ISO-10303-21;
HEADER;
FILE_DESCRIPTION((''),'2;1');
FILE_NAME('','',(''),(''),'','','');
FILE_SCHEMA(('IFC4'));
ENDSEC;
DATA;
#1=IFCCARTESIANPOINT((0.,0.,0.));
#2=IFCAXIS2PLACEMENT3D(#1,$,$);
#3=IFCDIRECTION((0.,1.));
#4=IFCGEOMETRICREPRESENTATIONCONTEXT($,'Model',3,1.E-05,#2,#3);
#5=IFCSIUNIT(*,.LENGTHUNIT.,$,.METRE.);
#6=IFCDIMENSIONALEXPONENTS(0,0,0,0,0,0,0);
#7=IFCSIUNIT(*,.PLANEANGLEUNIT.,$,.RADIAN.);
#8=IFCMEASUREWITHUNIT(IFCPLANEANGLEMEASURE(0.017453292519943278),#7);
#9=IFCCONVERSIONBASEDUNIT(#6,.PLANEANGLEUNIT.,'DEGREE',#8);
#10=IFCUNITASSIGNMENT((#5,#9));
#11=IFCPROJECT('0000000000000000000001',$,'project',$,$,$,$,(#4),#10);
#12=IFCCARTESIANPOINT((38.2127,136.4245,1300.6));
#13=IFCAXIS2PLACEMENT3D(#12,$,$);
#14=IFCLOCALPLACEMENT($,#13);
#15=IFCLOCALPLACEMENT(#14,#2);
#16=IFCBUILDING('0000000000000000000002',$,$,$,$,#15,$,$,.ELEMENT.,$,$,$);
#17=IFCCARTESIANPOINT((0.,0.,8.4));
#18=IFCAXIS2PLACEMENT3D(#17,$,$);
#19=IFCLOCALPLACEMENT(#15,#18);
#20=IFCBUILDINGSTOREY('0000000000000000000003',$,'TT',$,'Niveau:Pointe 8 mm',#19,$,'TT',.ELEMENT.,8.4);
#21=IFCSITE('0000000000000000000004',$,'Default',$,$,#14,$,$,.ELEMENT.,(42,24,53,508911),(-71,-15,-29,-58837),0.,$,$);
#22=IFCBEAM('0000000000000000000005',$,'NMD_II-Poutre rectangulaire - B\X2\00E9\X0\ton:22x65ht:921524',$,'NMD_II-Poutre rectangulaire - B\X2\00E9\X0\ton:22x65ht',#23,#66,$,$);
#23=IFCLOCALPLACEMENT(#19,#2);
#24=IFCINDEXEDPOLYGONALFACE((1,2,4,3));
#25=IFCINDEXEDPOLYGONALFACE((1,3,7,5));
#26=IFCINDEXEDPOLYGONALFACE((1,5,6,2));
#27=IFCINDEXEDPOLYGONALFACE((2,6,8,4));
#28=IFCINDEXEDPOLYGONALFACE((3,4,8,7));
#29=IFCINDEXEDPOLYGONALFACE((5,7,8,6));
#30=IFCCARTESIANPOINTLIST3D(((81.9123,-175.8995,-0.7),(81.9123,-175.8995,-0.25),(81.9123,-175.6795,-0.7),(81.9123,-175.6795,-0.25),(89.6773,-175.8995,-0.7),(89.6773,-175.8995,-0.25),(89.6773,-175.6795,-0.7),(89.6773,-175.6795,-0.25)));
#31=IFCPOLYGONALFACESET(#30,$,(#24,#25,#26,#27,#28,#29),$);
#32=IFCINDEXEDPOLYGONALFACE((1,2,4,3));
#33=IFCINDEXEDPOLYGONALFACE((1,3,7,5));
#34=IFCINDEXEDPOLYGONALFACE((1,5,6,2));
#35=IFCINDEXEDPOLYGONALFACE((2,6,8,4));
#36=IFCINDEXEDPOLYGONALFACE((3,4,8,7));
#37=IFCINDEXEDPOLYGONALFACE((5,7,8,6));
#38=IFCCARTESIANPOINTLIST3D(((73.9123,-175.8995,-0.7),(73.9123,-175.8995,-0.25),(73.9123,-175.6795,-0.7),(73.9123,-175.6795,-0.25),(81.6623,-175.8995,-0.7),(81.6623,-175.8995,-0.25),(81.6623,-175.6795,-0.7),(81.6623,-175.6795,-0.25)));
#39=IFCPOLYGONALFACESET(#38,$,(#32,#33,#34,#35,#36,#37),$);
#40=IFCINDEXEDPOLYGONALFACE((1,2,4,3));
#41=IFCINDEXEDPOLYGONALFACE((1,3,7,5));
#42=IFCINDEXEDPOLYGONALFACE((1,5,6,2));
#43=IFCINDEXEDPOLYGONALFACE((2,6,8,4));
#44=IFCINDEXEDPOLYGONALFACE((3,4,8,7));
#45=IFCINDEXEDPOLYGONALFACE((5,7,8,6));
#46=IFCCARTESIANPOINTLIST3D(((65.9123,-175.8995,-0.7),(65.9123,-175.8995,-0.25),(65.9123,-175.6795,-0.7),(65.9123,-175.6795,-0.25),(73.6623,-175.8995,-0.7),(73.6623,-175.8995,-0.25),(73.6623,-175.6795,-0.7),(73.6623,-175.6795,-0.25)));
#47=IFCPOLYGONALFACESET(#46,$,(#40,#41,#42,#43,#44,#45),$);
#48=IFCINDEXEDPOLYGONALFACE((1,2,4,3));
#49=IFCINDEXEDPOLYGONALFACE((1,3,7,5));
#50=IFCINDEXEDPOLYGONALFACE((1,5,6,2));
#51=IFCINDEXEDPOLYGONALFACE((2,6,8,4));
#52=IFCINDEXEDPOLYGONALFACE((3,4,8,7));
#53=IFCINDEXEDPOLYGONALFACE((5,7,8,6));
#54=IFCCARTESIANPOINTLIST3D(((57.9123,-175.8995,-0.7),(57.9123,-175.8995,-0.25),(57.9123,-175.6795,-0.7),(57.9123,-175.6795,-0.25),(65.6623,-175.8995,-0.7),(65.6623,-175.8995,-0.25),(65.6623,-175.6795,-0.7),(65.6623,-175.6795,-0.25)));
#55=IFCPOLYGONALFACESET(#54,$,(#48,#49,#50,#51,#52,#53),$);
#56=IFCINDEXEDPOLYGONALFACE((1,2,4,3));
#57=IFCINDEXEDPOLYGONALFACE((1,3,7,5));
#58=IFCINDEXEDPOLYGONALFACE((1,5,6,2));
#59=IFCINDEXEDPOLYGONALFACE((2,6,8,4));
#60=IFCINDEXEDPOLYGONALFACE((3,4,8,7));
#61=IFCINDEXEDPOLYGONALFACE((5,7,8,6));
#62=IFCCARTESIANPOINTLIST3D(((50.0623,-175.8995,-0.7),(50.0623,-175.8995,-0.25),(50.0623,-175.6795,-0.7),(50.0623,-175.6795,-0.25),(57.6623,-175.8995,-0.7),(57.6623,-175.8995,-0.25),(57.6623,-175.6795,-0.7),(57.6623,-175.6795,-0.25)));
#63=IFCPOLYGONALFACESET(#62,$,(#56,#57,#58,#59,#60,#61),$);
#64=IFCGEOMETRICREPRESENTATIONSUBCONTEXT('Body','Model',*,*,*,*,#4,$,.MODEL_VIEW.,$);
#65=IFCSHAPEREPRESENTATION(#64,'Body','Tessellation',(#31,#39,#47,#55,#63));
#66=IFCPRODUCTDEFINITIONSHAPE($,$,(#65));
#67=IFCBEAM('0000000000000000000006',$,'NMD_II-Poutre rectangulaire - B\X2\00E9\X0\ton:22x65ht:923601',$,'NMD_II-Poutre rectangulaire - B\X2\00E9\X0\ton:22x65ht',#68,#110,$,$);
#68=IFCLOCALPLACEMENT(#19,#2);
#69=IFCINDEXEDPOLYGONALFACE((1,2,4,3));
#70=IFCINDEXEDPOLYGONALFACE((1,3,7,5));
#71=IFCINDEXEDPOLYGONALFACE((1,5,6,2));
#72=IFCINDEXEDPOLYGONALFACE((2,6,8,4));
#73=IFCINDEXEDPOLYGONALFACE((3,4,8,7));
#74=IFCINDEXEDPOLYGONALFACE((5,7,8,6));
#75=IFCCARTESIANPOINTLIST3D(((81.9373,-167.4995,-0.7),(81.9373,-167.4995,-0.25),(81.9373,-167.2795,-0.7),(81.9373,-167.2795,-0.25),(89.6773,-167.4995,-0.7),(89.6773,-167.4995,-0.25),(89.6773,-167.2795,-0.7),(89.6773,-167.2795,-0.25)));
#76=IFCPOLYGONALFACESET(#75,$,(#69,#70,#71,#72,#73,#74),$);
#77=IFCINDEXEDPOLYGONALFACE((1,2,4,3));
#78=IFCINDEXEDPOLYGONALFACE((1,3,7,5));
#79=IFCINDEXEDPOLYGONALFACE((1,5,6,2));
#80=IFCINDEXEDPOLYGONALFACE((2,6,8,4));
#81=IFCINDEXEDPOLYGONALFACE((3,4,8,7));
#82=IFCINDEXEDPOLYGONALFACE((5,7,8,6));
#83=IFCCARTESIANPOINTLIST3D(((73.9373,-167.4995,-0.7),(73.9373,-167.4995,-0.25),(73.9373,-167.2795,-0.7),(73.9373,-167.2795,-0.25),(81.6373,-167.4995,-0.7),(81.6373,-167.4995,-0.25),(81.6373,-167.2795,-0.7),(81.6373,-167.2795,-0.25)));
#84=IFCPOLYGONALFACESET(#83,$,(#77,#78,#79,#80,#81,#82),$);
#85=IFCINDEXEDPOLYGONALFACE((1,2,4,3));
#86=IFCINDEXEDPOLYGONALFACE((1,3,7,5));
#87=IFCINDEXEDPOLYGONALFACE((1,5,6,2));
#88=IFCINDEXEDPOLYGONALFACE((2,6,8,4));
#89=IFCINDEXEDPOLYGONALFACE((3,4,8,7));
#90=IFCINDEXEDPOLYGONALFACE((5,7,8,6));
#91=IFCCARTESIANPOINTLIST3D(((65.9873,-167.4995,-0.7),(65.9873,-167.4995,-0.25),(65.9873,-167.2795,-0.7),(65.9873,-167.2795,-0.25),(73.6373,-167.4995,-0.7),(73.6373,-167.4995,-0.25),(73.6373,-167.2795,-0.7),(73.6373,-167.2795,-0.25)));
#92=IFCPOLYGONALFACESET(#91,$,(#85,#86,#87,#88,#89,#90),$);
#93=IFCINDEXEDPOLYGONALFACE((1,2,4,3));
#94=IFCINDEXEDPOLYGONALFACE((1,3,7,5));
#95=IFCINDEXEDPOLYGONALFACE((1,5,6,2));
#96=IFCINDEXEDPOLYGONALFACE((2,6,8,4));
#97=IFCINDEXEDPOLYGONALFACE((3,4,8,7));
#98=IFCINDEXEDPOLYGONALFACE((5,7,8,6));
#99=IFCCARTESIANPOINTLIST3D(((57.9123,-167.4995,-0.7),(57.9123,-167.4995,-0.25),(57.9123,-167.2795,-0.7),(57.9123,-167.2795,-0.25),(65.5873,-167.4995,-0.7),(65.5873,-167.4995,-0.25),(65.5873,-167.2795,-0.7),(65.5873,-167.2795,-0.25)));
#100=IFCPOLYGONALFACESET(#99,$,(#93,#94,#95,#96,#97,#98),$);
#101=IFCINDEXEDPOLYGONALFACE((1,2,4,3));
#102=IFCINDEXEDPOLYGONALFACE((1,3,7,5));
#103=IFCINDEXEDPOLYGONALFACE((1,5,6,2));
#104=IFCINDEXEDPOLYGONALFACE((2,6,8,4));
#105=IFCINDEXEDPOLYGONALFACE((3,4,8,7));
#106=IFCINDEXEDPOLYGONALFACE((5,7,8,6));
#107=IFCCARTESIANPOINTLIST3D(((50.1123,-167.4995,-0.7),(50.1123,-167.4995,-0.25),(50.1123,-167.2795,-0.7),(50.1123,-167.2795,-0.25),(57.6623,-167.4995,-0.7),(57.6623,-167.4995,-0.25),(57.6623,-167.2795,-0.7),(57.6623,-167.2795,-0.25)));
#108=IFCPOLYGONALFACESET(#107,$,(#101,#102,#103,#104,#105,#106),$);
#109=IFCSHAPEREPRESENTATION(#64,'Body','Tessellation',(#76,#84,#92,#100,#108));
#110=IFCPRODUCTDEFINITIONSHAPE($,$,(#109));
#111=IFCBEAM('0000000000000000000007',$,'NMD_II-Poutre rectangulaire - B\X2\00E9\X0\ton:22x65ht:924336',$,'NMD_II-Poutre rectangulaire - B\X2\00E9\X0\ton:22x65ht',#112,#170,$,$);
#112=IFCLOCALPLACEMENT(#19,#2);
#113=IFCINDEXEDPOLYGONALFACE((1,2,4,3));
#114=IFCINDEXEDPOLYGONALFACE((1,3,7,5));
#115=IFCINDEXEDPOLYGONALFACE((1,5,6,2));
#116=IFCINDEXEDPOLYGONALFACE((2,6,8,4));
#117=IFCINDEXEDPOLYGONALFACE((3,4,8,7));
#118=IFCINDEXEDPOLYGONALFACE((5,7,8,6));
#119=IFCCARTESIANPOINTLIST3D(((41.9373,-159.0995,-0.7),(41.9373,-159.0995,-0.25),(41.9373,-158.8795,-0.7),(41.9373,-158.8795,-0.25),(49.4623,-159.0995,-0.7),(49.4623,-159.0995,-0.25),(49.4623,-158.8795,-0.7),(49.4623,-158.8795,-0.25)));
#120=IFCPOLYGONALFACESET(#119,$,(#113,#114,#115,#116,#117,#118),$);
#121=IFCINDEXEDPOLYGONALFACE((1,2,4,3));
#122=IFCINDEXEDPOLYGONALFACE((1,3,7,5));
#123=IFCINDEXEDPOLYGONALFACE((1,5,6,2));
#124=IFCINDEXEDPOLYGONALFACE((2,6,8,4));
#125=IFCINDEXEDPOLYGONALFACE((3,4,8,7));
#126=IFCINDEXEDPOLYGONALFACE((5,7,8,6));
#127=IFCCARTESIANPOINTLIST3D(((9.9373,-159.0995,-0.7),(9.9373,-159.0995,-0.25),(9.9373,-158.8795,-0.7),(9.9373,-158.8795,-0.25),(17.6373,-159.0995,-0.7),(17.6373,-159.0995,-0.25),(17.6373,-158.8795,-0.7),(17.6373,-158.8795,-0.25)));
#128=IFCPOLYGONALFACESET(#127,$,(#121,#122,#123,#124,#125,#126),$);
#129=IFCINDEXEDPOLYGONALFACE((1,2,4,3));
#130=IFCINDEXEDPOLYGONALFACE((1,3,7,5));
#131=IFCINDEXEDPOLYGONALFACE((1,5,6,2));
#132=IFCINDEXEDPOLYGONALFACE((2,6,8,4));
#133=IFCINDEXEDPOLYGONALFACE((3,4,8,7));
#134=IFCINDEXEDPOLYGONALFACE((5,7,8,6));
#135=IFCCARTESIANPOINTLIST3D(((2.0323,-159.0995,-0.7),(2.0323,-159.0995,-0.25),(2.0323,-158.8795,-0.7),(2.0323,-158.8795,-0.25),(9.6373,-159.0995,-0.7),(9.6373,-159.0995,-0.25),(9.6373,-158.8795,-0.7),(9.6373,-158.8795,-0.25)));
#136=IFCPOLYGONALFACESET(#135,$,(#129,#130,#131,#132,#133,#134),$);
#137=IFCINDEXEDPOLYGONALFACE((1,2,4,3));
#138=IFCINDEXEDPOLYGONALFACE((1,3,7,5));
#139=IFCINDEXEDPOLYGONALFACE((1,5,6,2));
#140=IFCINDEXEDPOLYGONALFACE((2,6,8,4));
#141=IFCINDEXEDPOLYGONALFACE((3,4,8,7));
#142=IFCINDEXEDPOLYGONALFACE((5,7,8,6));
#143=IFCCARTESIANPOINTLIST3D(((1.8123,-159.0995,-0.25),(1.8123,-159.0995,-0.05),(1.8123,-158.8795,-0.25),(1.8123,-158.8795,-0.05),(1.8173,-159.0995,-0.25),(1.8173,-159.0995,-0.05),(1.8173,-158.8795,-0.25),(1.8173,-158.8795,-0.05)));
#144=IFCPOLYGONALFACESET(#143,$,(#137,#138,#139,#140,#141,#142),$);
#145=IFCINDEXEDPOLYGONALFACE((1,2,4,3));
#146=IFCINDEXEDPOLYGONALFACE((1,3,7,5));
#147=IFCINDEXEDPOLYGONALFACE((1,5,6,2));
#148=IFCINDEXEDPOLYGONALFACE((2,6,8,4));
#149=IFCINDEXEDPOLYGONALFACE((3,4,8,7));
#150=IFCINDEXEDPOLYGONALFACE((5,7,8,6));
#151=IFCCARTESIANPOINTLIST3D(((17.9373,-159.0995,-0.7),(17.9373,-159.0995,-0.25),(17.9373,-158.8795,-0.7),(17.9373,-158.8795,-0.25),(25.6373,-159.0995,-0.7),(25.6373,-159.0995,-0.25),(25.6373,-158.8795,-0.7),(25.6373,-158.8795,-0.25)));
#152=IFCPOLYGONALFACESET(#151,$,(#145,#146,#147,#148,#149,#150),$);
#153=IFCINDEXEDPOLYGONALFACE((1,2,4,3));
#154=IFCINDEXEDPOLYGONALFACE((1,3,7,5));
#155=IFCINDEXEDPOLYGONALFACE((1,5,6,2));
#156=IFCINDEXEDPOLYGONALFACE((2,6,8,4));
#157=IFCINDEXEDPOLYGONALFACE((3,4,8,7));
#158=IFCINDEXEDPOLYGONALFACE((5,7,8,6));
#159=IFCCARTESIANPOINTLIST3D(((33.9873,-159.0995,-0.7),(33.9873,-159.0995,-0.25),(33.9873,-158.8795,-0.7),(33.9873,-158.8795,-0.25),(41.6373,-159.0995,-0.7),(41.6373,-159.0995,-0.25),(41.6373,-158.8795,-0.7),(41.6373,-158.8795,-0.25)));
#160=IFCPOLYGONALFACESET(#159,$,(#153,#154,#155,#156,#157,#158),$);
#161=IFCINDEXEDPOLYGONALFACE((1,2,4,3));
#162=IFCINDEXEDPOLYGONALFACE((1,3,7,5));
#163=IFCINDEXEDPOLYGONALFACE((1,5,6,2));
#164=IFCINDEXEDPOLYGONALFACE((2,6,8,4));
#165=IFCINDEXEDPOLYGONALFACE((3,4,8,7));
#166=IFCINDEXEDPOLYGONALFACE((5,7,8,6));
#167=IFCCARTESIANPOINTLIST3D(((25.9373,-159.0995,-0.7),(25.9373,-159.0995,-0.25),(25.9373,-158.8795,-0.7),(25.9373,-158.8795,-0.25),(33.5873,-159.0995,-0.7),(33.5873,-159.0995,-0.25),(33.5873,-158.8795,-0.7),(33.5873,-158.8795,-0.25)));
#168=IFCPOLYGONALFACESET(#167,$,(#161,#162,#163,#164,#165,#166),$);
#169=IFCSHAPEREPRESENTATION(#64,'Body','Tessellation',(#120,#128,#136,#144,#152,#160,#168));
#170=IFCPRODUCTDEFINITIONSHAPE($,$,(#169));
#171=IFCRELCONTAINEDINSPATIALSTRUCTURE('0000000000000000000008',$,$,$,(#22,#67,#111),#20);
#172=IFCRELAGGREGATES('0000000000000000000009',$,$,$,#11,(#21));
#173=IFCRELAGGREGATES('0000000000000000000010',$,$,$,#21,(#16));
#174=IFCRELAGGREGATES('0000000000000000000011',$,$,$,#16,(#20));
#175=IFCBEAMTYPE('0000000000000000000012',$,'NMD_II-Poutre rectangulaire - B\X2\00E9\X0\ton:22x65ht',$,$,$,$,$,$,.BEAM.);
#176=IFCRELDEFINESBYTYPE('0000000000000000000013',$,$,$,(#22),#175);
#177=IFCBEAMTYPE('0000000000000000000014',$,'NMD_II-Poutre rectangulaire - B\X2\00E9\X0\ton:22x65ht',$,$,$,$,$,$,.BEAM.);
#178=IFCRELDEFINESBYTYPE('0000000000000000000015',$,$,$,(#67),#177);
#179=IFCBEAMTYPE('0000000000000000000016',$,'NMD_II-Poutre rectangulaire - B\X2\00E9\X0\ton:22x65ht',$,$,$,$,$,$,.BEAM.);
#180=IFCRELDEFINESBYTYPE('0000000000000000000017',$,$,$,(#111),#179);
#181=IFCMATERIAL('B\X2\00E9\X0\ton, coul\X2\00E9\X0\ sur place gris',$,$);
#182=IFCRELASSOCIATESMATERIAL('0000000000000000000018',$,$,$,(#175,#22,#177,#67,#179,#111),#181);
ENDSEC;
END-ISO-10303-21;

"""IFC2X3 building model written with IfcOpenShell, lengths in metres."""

from ifc_helpers import new_model, entity, si_unit, converted_unit, direction, frame, frame_2d, origin, place, context, subcontext, project, spatial, rectangle, extrude, source, transform, mapped, material, type_object, type_shapes, element, save


model = new_model("IFC2X3")

# Units and contexts
model_context = context("Model", 3, precision=1e-05, world=origin(), true_north=direction((0.0, 1.0)))
body_context = subcontext(model_context, "Body", "Model", "MODEL_VIEW")
ifc_project = project(units=[si_unit("LENGTHUNIT", "METRE"), converted_unit("PLANEANGLEUNIT", "DEGREE", entity("IfcPlaneAngleMeasure", 0.017453292519943278), si_unit("PLANEANGLEUNIT", "RADIAN"), dimensions=[0, 0, 0, 0, 0, 0, 0])], contexts=[model_context])

# Site, building, storey
site_placement = place(None, frame((38.2127, 136.4245, 1300.6)))
site = spatial("IfcSite", under=ifc_project, at=site_placement, Name="Default", CompositionType="ELEMENT", RefLatitude=(42, 24, 53, 508911), RefLongitude=(-71, -15, -29, -58837), RefElevation=0.0)
building_placement = place(site_placement, origin())
building = spatial("IfcBuilding", under=site, at=building_placement, CompositionType="ELEMENT")
storey_placement = place(building_placement, frame((0.0, 0.0, 8.4)))
storey = spatial("IfcBuildingStorey", under=building, at=storey_placement, Name="TT", ObjectType="Niveau:Pointe 8 mm", LongName="TT", CompositionType="ELEMENT", Elevation=8.4)

# Beams
ifc_material_1 = material(Name="Béton, coulé sur place gris")
beam_type_1 = type_object("IfcBeamType", Name="NMD_II-Poutre rectangulaire - Béton:22x65ht", PredefinedType="BEAM", material=ifc_material_1)
shared_shape_1 = source(origin(), body_context, "Body", "SweptSolid", [
    extrude(rectangle(XDim=0.45, YDim=0.22, at=frame_2d((0.0, 0.0), x_axis=(1.0, 0.0))), frame((81.9123, -175.7895, 7.925), z_axis=(1.0, 0.0, 0.0), x_axis=(0.0, 0.0, -1.0)), (0.0, 0.0, 1.0), 7.765),
    extrude(rectangle(XDim=0.45, YDim=0.22, at=frame_2d((0.0, 0.0), x_axis=(1.0, 0.0))), frame((73.9123, -175.7895, 7.925), z_axis=(1.0, 0.0, 0.0), x_axis=(0.0, 0.0, -1.0)), (0.0, 0.0, 1.0), 7.75),
    extrude(rectangle(XDim=0.45, YDim=0.22, at=frame_2d((0.0, 0.0), x_axis=(1.0, 0.0))), frame((65.9123, -175.7895, 7.925), z_axis=(1.0, 0.0, 0.0), x_axis=(0.0, 0.0, -1.0)), (0.0, 0.0, 1.0), 7.75),
    extrude(rectangle(XDim=0.45, YDim=0.22, at=frame_2d((0.0, 0.0), x_axis=(1.0, 0.0))), frame((57.9123, -175.7895, 7.925), z_axis=(1.0, 0.0, 0.0), x_axis=(0.0, 0.0, -1.0)), (0.0, 0.0, 1.0), 7.75),
    extrude(rectangle(XDim=0.45, YDim=0.22, at=frame_2d((0.0, 0.0), x_axis=(1.0, 0.0))), frame((50.0623, -175.7895, 7.925), z_axis=(1.0, 0.0, 0.0), x_axis=(0.0, 0.0, -1.0)), (0.0, 0.0, 1.0), 7.6),
])
type_shapes(beam_type_1, [shared_shape_1])
beam_1_placement = place(storey_placement, frame((0.0, 0.0, -8.4)))
element("IfcBeam", 1, at=beam_1_placement, inside=storey, type_object=beam_type_1, material=ifc_material_1, Name="NMD_II-Poutre rectangulaire - Béton:22x65ht:921524", ObjectType="NMD_II-Poutre rectangulaire - Béton:22x65ht", context=body_context, shape_type="MappedRepresentation", body=[
    mapped(shared_shape_1, transform((0.0, 0.0, 0.0), scale=1.0)),
])
beam_type_2 = type_object("IfcBeamType", Name="NMD_II-Poutre rectangulaire - Béton:22x65ht", PredefinedType="BEAM", material=ifc_material_1)
shared_shape_2 = source(origin(), body_context, "Body", "SweptSolid", [
    extrude(rectangle(XDim=0.45, YDim=0.22, at=frame_2d((0.0, 0.0), x_axis=(1.0, 0.0))), frame((81.9373, -167.3895, 7.925), z_axis=(1.0, 0.0, 0.0), x_axis=(0.0, 0.0, -1.0)), (0.0, 0.0, 1.0), 7.74),
    extrude(rectangle(XDim=0.45, YDim=0.22, at=frame_2d((0.0, 0.0), x_axis=(1.0, 0.0))), frame((73.9373, -167.3895, 7.925), z_axis=(1.0, 0.0, 0.0), x_axis=(0.0, 0.0, -1.0)), (0.0, 0.0, 1.0), 7.7),
    extrude(rectangle(XDim=0.45, YDim=0.22, at=frame_2d((0.0, 0.0), x_axis=(1.0, 0.0))), frame((65.9873, -167.3895, 7.925), z_axis=(1.0, 0.0, 0.0), x_axis=(0.0, 0.0, -1.0)), (0.0, 0.0, 1.0), 7.65),
    extrude(rectangle(XDim=0.45, YDim=0.22, at=frame_2d((0.0, 0.0), x_axis=(1.0, 0.0))), frame((57.9123, -167.3895, 7.925), z_axis=(1.0, 0.0, 0.0), x_axis=(0.0, 0.0, -1.0)), (0.0, 0.0, 1.0), 7.675),
    extrude(rectangle(XDim=0.45, YDim=0.22, at=frame_2d((0.0, 0.0), x_axis=(1.0, 0.0))), frame((50.1123, -167.3895, 7.925), z_axis=(1.0, 0.0, 0.0), x_axis=(0.0, 0.0, -1.0)), (0.0, 0.0, 1.0), 7.55),
])
type_shapes(beam_type_2, [shared_shape_2])
beam_2_placement = place(storey_placement, frame((0.0, 0.0, -8.4)))
element("IfcBeam", 2, at=beam_2_placement, inside=storey, type_object=beam_type_2, material=ifc_material_1, Name="NMD_II-Poutre rectangulaire - Béton:22x65ht:923601", ObjectType="NMD_II-Poutre rectangulaire - Béton:22x65ht", context=body_context, shape_type="MappedRepresentation", body=[
    mapped(shared_shape_2, transform((0.0, 0.0, 0.0), scale=1.0)),
])
beam_type_3 = type_object("IfcBeamType", Name="NMD_II-Poutre rectangulaire - Béton:22x65ht", PredefinedType="BEAM", material=ifc_material_1)
shared_shape_3 = source(origin(), body_context, "Body", "SweptSolid", [
    extrude(rectangle(XDim=0.45, YDim=0.22, at=frame_2d((0.0, 0.0), x_axis=(1.0, 0.0))), frame((41.9373, -158.9895, 7.925), z_axis=(1.0, 0.0, 0.0), x_axis=(0.0, 0.0, -1.0)), (0.0, 0.0, 1.0), 7.525),
    extrude(rectangle(XDim=0.45, YDim=0.22, at=frame_2d((0.0, 0.0), x_axis=(1.0, 0.0))), frame((9.9373, -158.9895, 7.925), z_axis=(1.0, 0.0, 0.0), x_axis=(0.0, 0.0, -1.0)), (0.0, 0.0, 1.0), 7.7),
    extrude(rectangle(XDim=0.45, YDim=0.22, at=frame_2d((0.0, 0.0), x_axis=(1.0, 0.0))), frame((2.0323, -158.9895, 7.925), z_axis=(1.0, 0.0, 0.0), x_axis=(0.0, 0.0, -1.0)), (0.0, 0.0, 1.0), 7.605),
    extrude(rectangle(XDim=0.2, YDim=0.22, at=frame_2d((0.0, 0.0), x_axis=(1.0, 0.0))), frame((1.8123, -158.9895, 8.25), z_axis=(1.0, 0.0, 0.0), x_axis=(0.0, 0.0, -1.0)), (0.0, 0.0, 1.0), 0.005),
    extrude(rectangle(XDim=0.45, YDim=0.22, at=frame_2d((0.0, 0.0), x_axis=(1.0, 0.0))), frame((17.9373, -158.9895, 7.925), z_axis=(1.0, 0.0, 0.0), x_axis=(0.0, 0.0, -1.0)), (0.0, 0.0, 1.0), 7.7),
    extrude(rectangle(XDim=0.45, YDim=0.22, at=frame_2d((0.0, 0.0), x_axis=(1.0, 0.0))), frame((33.9873, -158.9895, 7.925), z_axis=(1.0, 0.0, 0.0), x_axis=(0.0, 0.0, -1.0)), (0.0, 0.0, 1.0), 7.65),
    extrude(rectangle(XDim=0.45, YDim=0.22, at=frame_2d((0.0, 0.0), x_axis=(1.0, 0.0))), frame((25.9373, -158.9895, 7.925), z_axis=(1.0, 0.0, 0.0), x_axis=(0.0, 0.0, -1.0)), (0.0, 0.0, 1.0), 7.65),
])
type_shapes(beam_type_3, [shared_shape_3])
beam_3_placement = place(storey_placement, frame((0.0, 0.0, -8.4)))
element("IfcBeam", 3, at=beam_3_placement, inside=storey, type_object=beam_type_3, material=ifc_material_1, Name="NMD_II-Poutre rectangulaire - Béton:22x65ht:924336", ObjectType="NMD_II-Poutre rectangulaire - Béton:22x65ht", context=body_context, shape_type="MappedRepresentation", body=[
    mapped(shared_shape_3, transform((0.0, 0.0, 0.0), scale=1.0)),
])

save(model, "model.ifc")
